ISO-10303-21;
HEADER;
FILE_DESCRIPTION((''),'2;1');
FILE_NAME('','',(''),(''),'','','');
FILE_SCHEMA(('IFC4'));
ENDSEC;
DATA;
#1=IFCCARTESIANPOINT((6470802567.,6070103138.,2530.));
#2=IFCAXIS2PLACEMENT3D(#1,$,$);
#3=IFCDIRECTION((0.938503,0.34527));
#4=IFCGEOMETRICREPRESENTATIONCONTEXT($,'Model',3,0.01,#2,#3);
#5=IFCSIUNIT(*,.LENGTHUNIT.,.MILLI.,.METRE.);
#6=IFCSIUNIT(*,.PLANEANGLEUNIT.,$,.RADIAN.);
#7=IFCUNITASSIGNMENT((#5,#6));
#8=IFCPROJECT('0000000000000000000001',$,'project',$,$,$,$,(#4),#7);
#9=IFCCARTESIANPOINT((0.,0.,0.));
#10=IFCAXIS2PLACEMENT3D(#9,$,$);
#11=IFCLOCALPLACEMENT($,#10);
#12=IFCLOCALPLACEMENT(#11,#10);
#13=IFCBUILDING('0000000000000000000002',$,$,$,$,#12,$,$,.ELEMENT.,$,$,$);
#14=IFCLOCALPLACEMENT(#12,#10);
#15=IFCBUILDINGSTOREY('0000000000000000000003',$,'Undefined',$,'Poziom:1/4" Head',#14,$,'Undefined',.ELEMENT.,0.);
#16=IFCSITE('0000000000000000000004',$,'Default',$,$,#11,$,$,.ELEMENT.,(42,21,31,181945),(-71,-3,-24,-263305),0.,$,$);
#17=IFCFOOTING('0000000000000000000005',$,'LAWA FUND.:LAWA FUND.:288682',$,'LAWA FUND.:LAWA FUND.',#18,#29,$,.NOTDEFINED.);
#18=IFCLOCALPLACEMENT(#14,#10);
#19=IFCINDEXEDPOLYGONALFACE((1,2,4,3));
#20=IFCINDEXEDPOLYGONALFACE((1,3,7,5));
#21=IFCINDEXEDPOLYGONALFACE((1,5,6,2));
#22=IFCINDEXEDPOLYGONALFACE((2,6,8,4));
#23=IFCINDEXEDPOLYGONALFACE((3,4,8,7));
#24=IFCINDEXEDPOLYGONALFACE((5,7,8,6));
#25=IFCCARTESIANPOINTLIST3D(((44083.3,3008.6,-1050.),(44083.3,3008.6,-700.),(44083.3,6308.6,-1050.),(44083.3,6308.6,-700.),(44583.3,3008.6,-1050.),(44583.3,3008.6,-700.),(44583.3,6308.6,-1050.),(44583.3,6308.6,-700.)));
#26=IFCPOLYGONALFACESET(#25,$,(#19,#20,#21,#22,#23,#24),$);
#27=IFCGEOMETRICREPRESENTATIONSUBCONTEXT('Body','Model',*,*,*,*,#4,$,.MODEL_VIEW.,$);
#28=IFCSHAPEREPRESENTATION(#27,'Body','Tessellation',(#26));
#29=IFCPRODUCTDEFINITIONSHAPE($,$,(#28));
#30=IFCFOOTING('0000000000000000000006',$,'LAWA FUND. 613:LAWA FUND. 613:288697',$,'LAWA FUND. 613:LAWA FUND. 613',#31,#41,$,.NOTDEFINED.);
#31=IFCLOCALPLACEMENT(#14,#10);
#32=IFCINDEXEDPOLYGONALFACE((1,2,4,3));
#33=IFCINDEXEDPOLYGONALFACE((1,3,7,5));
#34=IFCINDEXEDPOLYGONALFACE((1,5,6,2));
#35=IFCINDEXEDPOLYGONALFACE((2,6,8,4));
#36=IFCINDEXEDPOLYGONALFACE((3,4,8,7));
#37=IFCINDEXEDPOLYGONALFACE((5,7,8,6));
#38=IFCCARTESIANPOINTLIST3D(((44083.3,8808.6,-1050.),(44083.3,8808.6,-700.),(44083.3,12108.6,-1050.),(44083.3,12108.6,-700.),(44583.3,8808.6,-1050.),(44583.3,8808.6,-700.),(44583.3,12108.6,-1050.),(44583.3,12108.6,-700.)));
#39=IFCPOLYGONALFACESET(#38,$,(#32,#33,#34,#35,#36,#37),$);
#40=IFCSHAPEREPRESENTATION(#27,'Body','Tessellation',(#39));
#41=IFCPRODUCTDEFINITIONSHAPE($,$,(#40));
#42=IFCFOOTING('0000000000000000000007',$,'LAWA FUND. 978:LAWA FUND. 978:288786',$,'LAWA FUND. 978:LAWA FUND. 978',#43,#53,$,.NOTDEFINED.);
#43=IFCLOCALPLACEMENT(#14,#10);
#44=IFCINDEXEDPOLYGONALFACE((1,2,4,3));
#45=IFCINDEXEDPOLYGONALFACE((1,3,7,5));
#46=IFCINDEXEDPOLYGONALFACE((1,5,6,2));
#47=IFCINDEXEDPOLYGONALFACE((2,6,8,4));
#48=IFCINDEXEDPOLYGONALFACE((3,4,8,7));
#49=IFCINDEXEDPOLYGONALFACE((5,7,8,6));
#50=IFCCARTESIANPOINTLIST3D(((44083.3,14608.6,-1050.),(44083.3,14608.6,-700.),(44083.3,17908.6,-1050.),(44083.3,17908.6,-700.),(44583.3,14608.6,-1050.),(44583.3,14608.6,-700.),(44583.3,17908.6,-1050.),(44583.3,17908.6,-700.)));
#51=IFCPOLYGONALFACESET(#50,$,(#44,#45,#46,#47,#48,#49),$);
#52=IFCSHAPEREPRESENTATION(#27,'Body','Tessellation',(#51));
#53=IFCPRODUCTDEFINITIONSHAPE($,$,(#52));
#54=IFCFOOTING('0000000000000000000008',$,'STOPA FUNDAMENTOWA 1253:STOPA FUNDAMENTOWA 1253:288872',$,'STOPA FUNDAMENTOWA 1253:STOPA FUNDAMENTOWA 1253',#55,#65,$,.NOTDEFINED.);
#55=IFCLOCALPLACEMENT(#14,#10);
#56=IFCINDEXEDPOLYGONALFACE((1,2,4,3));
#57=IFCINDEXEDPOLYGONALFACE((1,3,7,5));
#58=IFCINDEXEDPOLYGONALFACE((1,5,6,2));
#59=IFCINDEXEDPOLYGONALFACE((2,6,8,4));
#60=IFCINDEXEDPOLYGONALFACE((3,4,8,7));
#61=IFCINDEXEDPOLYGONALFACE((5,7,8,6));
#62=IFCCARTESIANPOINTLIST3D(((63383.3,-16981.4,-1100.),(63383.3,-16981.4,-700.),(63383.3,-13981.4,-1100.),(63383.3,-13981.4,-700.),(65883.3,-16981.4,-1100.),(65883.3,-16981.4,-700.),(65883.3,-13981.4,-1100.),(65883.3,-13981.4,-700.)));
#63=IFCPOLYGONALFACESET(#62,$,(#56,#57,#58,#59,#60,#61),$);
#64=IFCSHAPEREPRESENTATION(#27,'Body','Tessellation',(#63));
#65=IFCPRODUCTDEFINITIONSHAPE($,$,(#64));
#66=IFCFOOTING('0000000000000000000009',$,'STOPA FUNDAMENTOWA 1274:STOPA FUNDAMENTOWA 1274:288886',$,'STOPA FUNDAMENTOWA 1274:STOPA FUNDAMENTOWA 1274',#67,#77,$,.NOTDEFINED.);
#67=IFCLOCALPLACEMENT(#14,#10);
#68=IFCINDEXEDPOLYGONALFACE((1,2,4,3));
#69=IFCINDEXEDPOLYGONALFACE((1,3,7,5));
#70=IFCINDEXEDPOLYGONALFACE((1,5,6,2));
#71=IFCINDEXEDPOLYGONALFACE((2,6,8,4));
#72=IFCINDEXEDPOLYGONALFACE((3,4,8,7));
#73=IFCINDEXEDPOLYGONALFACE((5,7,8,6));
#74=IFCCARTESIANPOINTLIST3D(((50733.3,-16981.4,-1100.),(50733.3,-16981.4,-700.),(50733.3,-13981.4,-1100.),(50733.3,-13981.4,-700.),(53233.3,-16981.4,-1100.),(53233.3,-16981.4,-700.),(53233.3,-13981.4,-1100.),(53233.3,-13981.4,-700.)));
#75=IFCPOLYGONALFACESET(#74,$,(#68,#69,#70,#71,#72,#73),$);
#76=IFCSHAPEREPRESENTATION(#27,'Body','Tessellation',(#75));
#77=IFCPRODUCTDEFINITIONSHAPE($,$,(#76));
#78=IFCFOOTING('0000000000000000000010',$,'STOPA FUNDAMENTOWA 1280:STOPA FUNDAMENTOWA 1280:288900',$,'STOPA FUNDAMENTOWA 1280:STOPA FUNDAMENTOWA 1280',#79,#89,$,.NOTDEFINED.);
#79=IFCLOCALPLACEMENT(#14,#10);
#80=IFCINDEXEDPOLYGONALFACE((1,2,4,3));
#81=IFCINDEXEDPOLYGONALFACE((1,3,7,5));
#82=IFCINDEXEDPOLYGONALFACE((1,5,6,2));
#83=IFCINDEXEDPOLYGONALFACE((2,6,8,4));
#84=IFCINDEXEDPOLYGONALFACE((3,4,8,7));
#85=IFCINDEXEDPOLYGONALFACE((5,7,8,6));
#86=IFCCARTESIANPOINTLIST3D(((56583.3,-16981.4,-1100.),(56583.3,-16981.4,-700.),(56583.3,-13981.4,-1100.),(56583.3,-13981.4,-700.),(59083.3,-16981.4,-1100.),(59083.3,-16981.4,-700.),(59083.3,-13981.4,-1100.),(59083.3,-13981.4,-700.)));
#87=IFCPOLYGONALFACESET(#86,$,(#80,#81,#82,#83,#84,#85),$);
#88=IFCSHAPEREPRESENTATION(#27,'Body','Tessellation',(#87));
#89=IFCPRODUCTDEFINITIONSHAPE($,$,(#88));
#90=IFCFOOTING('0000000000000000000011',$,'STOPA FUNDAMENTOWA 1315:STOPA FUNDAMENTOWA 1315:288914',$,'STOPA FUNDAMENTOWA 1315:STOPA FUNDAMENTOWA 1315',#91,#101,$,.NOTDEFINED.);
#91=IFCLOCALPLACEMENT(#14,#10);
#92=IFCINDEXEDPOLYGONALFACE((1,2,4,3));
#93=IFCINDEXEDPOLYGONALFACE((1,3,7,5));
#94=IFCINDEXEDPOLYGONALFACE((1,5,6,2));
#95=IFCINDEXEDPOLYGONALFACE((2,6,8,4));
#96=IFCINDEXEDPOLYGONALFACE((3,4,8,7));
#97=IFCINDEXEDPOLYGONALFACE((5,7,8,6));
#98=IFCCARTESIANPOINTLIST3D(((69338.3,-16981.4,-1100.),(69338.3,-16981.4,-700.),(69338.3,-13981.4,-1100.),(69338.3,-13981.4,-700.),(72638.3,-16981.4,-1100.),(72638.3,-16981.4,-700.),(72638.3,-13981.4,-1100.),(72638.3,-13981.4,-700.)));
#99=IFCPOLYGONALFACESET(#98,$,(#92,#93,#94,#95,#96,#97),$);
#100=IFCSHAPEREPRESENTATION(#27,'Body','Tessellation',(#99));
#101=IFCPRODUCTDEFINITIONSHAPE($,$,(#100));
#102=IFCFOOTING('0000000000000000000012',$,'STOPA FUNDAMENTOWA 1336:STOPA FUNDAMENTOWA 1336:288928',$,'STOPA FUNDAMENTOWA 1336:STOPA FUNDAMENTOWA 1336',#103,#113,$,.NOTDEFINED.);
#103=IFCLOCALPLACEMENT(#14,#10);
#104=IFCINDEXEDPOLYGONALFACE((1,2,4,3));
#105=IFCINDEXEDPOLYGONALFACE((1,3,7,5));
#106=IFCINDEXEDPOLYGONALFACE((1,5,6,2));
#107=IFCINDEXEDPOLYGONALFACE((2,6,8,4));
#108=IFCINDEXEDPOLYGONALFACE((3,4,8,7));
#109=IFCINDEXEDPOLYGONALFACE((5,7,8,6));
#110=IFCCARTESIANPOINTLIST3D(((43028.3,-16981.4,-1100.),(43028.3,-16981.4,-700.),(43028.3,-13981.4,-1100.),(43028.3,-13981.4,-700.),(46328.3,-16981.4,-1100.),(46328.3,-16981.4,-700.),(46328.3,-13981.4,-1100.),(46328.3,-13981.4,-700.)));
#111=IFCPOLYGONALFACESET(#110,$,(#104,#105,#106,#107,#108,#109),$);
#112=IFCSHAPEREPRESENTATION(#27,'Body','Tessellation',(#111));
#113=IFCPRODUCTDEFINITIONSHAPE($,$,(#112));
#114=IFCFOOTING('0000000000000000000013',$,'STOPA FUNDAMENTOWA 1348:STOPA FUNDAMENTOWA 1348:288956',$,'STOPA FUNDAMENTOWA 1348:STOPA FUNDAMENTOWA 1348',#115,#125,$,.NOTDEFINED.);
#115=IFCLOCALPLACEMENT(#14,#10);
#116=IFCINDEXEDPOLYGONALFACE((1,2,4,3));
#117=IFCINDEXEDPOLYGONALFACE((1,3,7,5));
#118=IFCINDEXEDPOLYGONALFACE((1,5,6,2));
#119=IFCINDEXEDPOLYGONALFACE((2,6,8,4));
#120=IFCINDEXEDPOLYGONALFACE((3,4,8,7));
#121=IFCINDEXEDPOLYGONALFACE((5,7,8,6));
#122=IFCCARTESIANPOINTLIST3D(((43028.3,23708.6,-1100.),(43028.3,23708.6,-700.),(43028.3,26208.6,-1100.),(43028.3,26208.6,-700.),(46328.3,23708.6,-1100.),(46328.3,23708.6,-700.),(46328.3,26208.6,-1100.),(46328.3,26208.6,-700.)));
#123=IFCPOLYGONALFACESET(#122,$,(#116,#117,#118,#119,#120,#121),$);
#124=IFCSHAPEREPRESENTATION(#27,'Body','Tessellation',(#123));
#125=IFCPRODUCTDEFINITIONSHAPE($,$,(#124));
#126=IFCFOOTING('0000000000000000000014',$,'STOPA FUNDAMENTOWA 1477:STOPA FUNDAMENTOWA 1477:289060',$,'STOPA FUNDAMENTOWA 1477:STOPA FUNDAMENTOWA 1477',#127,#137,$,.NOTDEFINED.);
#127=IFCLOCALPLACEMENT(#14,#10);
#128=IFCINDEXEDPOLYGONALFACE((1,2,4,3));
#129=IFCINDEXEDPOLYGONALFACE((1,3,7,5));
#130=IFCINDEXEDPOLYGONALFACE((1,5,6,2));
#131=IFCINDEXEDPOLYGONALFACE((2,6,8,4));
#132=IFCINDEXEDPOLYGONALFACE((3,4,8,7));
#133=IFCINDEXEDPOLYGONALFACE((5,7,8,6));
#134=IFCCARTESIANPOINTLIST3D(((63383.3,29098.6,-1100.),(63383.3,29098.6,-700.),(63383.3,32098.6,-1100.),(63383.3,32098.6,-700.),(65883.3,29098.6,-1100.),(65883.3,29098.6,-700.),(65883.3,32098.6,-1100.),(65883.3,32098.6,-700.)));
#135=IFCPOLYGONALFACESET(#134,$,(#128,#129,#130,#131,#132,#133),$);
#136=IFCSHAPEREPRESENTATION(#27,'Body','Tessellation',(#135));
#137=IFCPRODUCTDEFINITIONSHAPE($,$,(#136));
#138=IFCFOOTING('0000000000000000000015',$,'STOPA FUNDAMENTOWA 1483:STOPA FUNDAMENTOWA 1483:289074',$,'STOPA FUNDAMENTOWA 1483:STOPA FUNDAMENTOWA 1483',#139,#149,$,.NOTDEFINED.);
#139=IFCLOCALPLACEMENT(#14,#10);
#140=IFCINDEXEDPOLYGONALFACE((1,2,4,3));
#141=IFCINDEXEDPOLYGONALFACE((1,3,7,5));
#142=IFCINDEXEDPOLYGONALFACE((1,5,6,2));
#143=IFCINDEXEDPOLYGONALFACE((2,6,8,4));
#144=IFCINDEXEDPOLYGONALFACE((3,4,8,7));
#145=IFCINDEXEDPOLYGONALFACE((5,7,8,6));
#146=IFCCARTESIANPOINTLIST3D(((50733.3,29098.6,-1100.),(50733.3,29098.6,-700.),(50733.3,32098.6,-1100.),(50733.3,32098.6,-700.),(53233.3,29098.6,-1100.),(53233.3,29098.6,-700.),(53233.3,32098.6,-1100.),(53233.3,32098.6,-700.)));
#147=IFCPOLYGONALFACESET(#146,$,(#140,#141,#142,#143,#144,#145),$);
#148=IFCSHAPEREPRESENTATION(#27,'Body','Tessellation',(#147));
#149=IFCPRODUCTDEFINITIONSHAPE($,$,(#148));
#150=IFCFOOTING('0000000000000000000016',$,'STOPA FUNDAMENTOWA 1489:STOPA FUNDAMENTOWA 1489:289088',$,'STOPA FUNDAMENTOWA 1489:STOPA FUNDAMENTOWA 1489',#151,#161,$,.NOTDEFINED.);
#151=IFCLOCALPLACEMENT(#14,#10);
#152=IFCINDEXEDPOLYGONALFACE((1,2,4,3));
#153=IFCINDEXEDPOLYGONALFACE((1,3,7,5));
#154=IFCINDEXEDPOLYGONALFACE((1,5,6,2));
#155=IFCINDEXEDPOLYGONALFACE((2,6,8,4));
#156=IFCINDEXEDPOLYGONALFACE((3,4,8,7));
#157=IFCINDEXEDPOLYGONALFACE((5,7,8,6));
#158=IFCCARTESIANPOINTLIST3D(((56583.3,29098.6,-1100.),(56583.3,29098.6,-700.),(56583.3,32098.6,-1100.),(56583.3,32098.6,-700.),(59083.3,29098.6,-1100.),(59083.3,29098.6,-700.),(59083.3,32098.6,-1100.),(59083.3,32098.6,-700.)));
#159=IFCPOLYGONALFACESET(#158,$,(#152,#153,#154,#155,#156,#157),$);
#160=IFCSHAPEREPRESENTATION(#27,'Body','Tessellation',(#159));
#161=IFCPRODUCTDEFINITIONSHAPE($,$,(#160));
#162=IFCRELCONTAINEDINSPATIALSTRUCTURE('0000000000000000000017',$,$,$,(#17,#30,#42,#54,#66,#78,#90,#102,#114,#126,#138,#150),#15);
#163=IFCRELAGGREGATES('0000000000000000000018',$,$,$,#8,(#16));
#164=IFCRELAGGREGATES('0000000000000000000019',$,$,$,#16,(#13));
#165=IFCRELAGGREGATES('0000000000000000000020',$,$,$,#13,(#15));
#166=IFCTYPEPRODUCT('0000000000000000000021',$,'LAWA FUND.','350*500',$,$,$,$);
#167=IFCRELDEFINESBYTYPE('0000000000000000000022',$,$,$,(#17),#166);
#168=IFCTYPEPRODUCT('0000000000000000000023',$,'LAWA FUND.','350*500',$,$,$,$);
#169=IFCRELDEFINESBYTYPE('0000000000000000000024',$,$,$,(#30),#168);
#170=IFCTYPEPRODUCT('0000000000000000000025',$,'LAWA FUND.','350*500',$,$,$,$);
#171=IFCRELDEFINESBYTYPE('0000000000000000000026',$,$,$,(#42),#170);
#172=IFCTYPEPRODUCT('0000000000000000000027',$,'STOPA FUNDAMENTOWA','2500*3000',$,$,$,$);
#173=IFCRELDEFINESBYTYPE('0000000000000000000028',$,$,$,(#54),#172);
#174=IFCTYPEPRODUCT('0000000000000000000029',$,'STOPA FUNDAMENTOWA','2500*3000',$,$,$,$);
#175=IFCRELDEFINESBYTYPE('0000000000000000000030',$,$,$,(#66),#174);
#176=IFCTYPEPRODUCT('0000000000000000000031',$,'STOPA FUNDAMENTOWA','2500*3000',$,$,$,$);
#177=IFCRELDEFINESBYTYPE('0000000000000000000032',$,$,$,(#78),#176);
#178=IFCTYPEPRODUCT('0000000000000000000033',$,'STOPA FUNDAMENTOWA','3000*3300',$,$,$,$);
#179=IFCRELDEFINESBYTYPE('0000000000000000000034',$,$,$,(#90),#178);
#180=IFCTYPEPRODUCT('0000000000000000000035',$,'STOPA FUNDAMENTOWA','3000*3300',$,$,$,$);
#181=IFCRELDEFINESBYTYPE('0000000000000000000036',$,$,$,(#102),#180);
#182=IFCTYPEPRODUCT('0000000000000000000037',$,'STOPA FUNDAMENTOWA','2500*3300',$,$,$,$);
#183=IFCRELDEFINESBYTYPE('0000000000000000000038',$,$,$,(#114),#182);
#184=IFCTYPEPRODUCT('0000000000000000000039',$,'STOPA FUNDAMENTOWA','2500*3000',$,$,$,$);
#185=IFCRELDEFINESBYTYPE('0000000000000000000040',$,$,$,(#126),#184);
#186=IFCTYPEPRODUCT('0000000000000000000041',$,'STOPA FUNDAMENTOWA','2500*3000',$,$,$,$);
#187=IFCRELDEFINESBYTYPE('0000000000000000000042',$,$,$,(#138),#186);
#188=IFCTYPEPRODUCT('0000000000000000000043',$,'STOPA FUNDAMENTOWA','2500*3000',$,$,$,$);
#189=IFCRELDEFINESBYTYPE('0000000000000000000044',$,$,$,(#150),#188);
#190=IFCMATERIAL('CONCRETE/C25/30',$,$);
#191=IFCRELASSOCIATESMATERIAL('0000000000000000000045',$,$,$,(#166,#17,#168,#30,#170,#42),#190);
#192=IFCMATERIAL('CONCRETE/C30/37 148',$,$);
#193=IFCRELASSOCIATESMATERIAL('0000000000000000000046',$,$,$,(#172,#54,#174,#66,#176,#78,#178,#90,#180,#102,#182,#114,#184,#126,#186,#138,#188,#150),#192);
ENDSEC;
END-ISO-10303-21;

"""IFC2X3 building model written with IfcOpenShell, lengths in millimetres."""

from ifc_helpers import new_model, si_unit, direction, frame, frame_2d, origin, origin_2d_with_axis, place, context, subcontext, project, spatial, rectangle, extrude, source, transform, mapped, material, type_object, type_shapes, element, save


model = new_model("IFC2X3")

# Units and contexts
model_context = context("Model", 3, precision=0.01, world=frame((6470802567.0, 6070103138.0, 2530.0)), true_north=direction((0.938503, 0.34527)))
body_context = subcontext(model_context, "Body", "Model", "MODEL_VIEW")
ifc_project = project(units=[si_unit("LENGTHUNIT", "METRE", prefix="MILLI"), si_unit("PLANEANGLEUNIT", "RADIAN")], contexts=[model_context])

# Site, building, storey
site_placement = place(None, origin())
site = spatial("IfcSite", under=ifc_project, at=site_placement, Name="Default", CompositionType="ELEMENT", RefLatitude=(42, 21, 31, 181945), RefLongitude=(-71, -3, -24, -263305), RefElevation=0.0)
building_placement = place(site_placement, origin())
building = spatial("IfcBuilding", under=site, at=building_placement, CompositionType="ELEMENT")
storey_placement = place(building_placement, origin())
storey = spatial("IfcBuildingStorey", under=building, at=storey_placement, Name="Undefined", ObjectType="Poziom:1/4\" Head", LongName="Undefined", CompositionType="ELEMENT", Elevation=0.0)

# Footings
ifc_material_1 = material(Name="CONCRETE/C25/30")
type_product_1 = type_object("IfcTypeProduct", Name="LAWA FUND.", Description="350*500", material=ifc_material_1)
shared_shape_1 = source(origin(), body_context, "Body", "SweptSolid", [
    extrude(rectangle(XDim=500.0, YDim=3300.0, at=frame_2d((0.0, 0.0), x_axis=(1.0, 0.0))), frame((44333.3, 4658.6, -1050.0), z_axis=(0.0, 0.0, 1.0), x_axis=(-1.0, 0.0, 0.0)), (0.0, 0.0, 1.0), 350.0),
])
type_shapes(type_product_1, [shared_shape_1])
footing_1_placement = place(storey_placement, origin())
element("IfcFooting", 1, at=footing_1_placement, inside=storey, type_object=type_product_1, material=ifc_material_1, Name="LAWA FUND.:LAWA FUND.:288682", ObjectType="LAWA FUND.:LAWA FUND.", PredefinedType="NOTDEFINED", context=body_context, shape_type="MappedRepresentation", body=[
    mapped(shared_shape_1, transform((0.0, 0.0, 0.0), scale=1.0)),
])
type_product_2 = type_object("IfcTypeProduct", Name="LAWA FUND.", Description="350*500", material=ifc_material_1)
shared_shape_2 = source(origin(), body_context, "Body", "SweptSolid", [
    extrude(rectangle(XDim=500.0, YDim=3300.0, at=frame_2d((0.0, 0.0), x_axis=(1.0, 0.0))), frame((44333.3, 10458.6, -1050.0), z_axis=(0.0, 0.0, 1.0), x_axis=(-1.0, 0.0, 0.0)), (0.0, 0.0, 1.0), 350.0),
])
type_shapes(type_product_2, [shared_shape_2])
footing_2_placement = place(storey_placement, origin())
element("IfcFooting", 2, at=footing_2_placement, inside=storey, type_object=type_product_2, material=ifc_material_1, Name="LAWA FUND. 613:LAWA FUND. 613:288697", ObjectType="LAWA FUND. 613:LAWA FUND. 613", PredefinedType="NOTDEFINED", context=body_context, shape_type="MappedRepresentation", body=[
    mapped(shared_shape_2, transform((0.0, 0.0, 0.0), scale=1.0)),
])
type_product_3 = type_object("IfcTypeProduct", Name="LAWA FUND.", Description="350*500", material=ifc_material_1)
shared_shape_3 = source(origin(), body_context, "Body", "SweptSolid", [
    extrude(rectangle(XDim=500.0, YDim=3300.0, at=frame_2d((0.0, 0.0), x_axis=(1.0, 0.0))), frame((44333.3, 16258.6, -1050.0), z_axis=(0.0, 0.0, 1.0), x_axis=(-1.0, 0.0, 0.0)), (0.0, 0.0, 1.0), 350.0),
])
type_shapes(type_product_3, [shared_shape_3])
footing_3_placement = place(storey_placement, origin())
element("IfcFooting", 3, at=footing_3_placement, inside=storey, type_object=type_product_3, material=ifc_material_1, Name="LAWA FUND. 978:LAWA FUND. 978:288786", ObjectType="LAWA FUND. 978:LAWA FUND. 978", PredefinedType="NOTDEFINED", context=body_context, shape_type="MappedRepresentation", body=[
    mapped(shared_shape_3, transform((0.0, 0.0, 0.0), scale=1.0)),
])
ifc_material_2 = material(Name="CONCRETE/C30/37 148")
type_product_4 = type_object("IfcTypeProduct", Name="STOPA FUNDAMENTOWA", Description="2500*3000", material=ifc_material_2)
shared_shape_4 = source(origin(), body_context, "Body", "SweptSolid", [
    extrude(rectangle(XDim=2500.0, YDim=3000.0, at=frame_2d((0.0, 0.0), x_axis=(1.0, 0.0))), frame((64633.3, -15481.4, -1100.0)), (0.0, 0.0, 1.0), 400.0),
])
type_shapes(type_product_4, [shared_shape_4])
footing_4_placement = place(storey_placement, origin())
element("IfcFooting", 4, at=footing_4_placement, inside=storey, type_object=type_product_4, material=ifc_material_2, Name="STOPA FUNDAMENTOWA 1253:STOPA FUNDAMENTOWA 1253:288872", ObjectType="STOPA FUNDAMENTOWA 1253:STOPA FUNDAMENTOWA 1253", PredefinedType="NOTDEFINED", context=body_context, shape_type="MappedRepresentation", body=[
    mapped(shared_shape_4, transform((0.0, 0.0, 0.0), scale=1.0)),
])
type_product_5 = type_object("IfcTypeProduct", Name="STOPA FUNDAMENTOWA", Description="2500*3000", material=ifc_material_2)
shared_shape_5 = source(origin(), body_context, "Body", "SweptSolid", [
    extrude(rectangle(XDim=2500.0, YDim=3000.0, at=frame_2d((0.0, 0.0), x_axis=(1.0, 0.0))), frame((51983.3, -15481.4, -1100.0)), (0.0, 0.0, 1.0), 400.0),
])
type_shapes(type_product_5, [shared_shape_5])
footing_5_placement = place(storey_placement, origin())
element("IfcFooting", 5, at=footing_5_placement, inside=storey, type_object=type_product_5, material=ifc_material_2, Name="STOPA FUNDAMENTOWA 1274:STOPA FUNDAMENTOWA 1274:288886", ObjectType="STOPA FUNDAMENTOWA 1274:STOPA FUNDAMENTOWA 1274", PredefinedType="NOTDEFINED", context=body_context, shape_type="MappedRepresentation", body=[
    mapped(shared_shape_5, transform((0.0, 0.0, 0.0), scale=1.0)),
])
type_product_6 = type_object("IfcTypeProduct", Name="STOPA FUNDAMENTOWA", Description="2500*3000", material=ifc_material_2)
shared_shape_6 = source(origin(), body_context, "Body", "SweptSolid", [
    extrude(rectangle(XDim=2500.0, YDim=3000.0, at=frame_2d((0.0, 0.0), x_axis=(1.0, 0.0))), frame((57833.3, -15481.4, -1100.0)), (0.0, 0.0, 1.0), 400.0),
])
type_shapes(type_product_6, [shared_shape_6])
footing_6_placement = place(storey_placement, origin())
element("IfcFooting", 6, at=footing_6_placement, inside=storey, type_object=type_product_6, material=ifc_material_2, Name="STOPA FUNDAMENTOWA 1280:STOPA FUNDAMENTOWA 1280:288900", ObjectType="STOPA FUNDAMENTOWA 1280:STOPA FUNDAMENTOWA 1280", PredefinedType="NOTDEFINED", context=body_context, shape_type="MappedRepresentation", body=[
    mapped(shared_shape_6, transform((0.0, 0.0, 0.0), scale=1.0)),
])
type_product_7 = type_object("IfcTypeProduct", Name="STOPA FUNDAMENTOWA", Description="3000*3300", material=ifc_material_2)
shared_shape_7 = source(origin(), body_context, "Body", "SweptSolid", [
    extrude(rectangle(XDim=3000.0, YDim=3300.0, at=frame_2d((0.0, 0.0), x_axis=(1.0, 0.0))), frame((70988.3, -15481.4, -1100.0), z_axis=(0.0, 0.0, 1.0), x_axis=(0.0, -1.0, 0.0)), (0.0, 0.0, 1.0), 400.0),
])
type_shapes(type_product_7, [shared_shape_7])
footing_7_placement = place(storey_placement, origin())
element("IfcFooting", 7, at=footing_7_placement, inside=storey, type_object=type_product_7, material=ifc_material_2, Name="STOPA FUNDAMENTOWA 1315:STOPA FUNDAMENTOWA 1315:288914", ObjectType="STOPA FUNDAMENTOWA 1315:STOPA FUNDAMENTOWA 1315", PredefinedType="NOTDEFINED", context=body_context, shape_type="MappedRepresentation", body=[
    mapped(shared_shape_7, transform((0.0, 0.0, 0.0), scale=1.0)),
])
type_product_8 = type_object("IfcTypeProduct", Name="STOPA FUNDAMENTOWA", Description="3000*3300", material=ifc_material_2)
shared_shape_8 = source(origin(), body_context, "Body", "SweptSolid", [
    extrude(rectangle(XDim=3000.0, YDim=3300.0, at=frame_2d((0.0, 0.0), x_axis=(1.0, 0.0))), frame((44678.3, -15481.4, -1100.0), z_axis=(0.0, 0.0, 1.0), x_axis=(0.0, -1.0, 0.0)), (0.0, 0.0, 1.0), 400.0),
])
type_shapes(type_product_8, [shared_shape_8])
footing_8_placement = place(storey_placement, origin())
element("IfcFooting", 8, at=footing_8_placement, inside=storey, type_object=type_product_8, material=ifc_material_2, Name="STOPA FUNDAMENTOWA 1336:STOPA FUNDAMENTOWA 1336:288928", ObjectType="STOPA FUNDAMENTOWA 1336:STOPA FUNDAMENTOWA 1336", PredefinedType="NOTDEFINED", context=body_context, shape_type="MappedRepresentation", body=[
    mapped(shared_shape_8, transform((0.0, 0.0, 0.0), scale=1.0)),
])
type_product_9 = type_object("IfcTypeProduct", Name="STOPA FUNDAMENTOWA", Description="2500*3300", material=ifc_material_2)
shared_shape_9 = source(origin(), body_context, "Body", "SweptSolid", [
    extrude(rectangle(XDim=2500.0, YDim=3300.0, at=frame_2d((0.0, 0.0), x_axis=(1.0, 0.0))), frame((44678.3, 24958.6, -1100.0), z_axis=(0.0, 0.0, 1.0), x_axis=(0.0, -1.0, 0.0)), (0.0, 0.0, 1.0), 400.0),
])
type_shapes(type_product_9, [shared_shape_9])
footing_9_placement = place(storey_placement, origin())
element("IfcFooting", 9, at=footing_9_placement, inside=storey, type_object=type_product_9, material=ifc_material_2, Name="STOPA FUNDAMENTOWA 1348:STOPA FUNDAMENTOWA 1348:288956", ObjectType="STOPA FUNDAMENTOWA 1348:STOPA FUNDAMENTOWA 1348", PredefinedType="NOTDEFINED", context=body_context, shape_type="MappedRepresentation", body=[
    mapped(shared_shape_9, transform((0.0, 0.0, 0.0), scale=1.0)),
])
type_product_10 = type_object("IfcTypeProduct", Name="STOPA FUNDAMENTOWA", Description="2500*3000", material=ifc_material_2)
shared_shape_10 = source(origin(), body_context, "Body", "SweptSolid", [
    extrude(rectangle(XDim=2500.0, YDim=3000.0, at=frame_2d((0.0, 0.0), x_axis=(1.0, 0.0))), frame((64633.3, 30598.6, -1100.0)), (0.0, 0.0, 1.0), 400.0),
])
type_shapes(type_product_10, [shared_shape_10])
footing_10_placement = place(storey_placement, origin())
element("IfcFooting", 10, at=footing_10_placement, inside=storey, type_object=type_product_10, material=ifc_material_2, Name="STOPA FUNDAMENTOWA 1477:STOPA FUNDAMENTOWA 1477:289060", ObjectType="STOPA FUNDAMENTOWA 1477:STOPA FUNDAMENTOWA 1477", PredefinedType="NOTDEFINED", context=body_context, shape_type="MappedRepresentation", body=[
    mapped(shared_shape_10, transform((0.0, 0.0, 0.0), scale=1.0)),
])
type_product_11 = type_object("IfcTypeProduct", Name="STOPA FUNDAMENTOWA", Description="2500*3000", material=ifc_material_2)
shared_shape_11 = source(origin(), body_context, "Body", "SweptSolid", [
    extrude(rectangle(XDim=2500.0, YDim=3000.0, at=frame_2d((0.0, 0.0), x_axis=(1.0, 0.0))), frame((51983.3, 30598.6, -1100.0)), (0.0, 0.0, 1.0), 400.0),
])
type_shapes(type_product_11, [shared_shape_11])
footing_11_placement = place(storey_placement, origin())
element("IfcFooting", 11, at=footing_11_placement, inside=storey, type_object=type_product_11, material=ifc_material_2, Name="STOPA FUNDAMENTOWA 1483:STOPA FUNDAMENTOWA 1483:289074", ObjectType="STOPA FUNDAMENTOWA 1483:STOPA FUNDAMENTOWA 1483", PredefinedType="NOTDEFINED", context=body_context, shape_type="MappedRepresentation", body=[
    mapped(shared_shape_11, transform((0.0, 0.0, 0.0), scale=1.0)),
])
type_product_12 = type_object("IfcTypeProduct", Name="STOPA FUNDAMENTOWA", Description="2500*3000", material=ifc_material_2)
shared_shape_12 = source(origin(), body_context, "Body", "SweptSolid", [
    extrude(rectangle(XDim=2500.0, YDim=3000.0, at=origin_2d_with_axis()), frame((57833.3, 30598.6, -1100.0)), (0.0, 0.0, 1.0), 400.0),
])
type_shapes(type_product_12, [shared_shape_12])
footing_12_placement = place(storey_placement, origin())
element("IfcFooting", 12, at=footing_12_placement, inside=storey, type_object=type_product_12, material=ifc_material_2, Name="STOPA FUNDAMENTOWA 1489:STOPA FUNDAMENTOWA 1489:289088", ObjectType="STOPA FUNDAMENTOWA 1489:STOPA FUNDAMENTOWA 1489", PredefinedType="NOTDEFINED", context=body_context, shape_type="MappedRepresentation", body=[
    mapped(shared_shape_12, transform((0.0, 0.0, 0.0), scale=1.0)),
])

save(model, "model.ifc")
